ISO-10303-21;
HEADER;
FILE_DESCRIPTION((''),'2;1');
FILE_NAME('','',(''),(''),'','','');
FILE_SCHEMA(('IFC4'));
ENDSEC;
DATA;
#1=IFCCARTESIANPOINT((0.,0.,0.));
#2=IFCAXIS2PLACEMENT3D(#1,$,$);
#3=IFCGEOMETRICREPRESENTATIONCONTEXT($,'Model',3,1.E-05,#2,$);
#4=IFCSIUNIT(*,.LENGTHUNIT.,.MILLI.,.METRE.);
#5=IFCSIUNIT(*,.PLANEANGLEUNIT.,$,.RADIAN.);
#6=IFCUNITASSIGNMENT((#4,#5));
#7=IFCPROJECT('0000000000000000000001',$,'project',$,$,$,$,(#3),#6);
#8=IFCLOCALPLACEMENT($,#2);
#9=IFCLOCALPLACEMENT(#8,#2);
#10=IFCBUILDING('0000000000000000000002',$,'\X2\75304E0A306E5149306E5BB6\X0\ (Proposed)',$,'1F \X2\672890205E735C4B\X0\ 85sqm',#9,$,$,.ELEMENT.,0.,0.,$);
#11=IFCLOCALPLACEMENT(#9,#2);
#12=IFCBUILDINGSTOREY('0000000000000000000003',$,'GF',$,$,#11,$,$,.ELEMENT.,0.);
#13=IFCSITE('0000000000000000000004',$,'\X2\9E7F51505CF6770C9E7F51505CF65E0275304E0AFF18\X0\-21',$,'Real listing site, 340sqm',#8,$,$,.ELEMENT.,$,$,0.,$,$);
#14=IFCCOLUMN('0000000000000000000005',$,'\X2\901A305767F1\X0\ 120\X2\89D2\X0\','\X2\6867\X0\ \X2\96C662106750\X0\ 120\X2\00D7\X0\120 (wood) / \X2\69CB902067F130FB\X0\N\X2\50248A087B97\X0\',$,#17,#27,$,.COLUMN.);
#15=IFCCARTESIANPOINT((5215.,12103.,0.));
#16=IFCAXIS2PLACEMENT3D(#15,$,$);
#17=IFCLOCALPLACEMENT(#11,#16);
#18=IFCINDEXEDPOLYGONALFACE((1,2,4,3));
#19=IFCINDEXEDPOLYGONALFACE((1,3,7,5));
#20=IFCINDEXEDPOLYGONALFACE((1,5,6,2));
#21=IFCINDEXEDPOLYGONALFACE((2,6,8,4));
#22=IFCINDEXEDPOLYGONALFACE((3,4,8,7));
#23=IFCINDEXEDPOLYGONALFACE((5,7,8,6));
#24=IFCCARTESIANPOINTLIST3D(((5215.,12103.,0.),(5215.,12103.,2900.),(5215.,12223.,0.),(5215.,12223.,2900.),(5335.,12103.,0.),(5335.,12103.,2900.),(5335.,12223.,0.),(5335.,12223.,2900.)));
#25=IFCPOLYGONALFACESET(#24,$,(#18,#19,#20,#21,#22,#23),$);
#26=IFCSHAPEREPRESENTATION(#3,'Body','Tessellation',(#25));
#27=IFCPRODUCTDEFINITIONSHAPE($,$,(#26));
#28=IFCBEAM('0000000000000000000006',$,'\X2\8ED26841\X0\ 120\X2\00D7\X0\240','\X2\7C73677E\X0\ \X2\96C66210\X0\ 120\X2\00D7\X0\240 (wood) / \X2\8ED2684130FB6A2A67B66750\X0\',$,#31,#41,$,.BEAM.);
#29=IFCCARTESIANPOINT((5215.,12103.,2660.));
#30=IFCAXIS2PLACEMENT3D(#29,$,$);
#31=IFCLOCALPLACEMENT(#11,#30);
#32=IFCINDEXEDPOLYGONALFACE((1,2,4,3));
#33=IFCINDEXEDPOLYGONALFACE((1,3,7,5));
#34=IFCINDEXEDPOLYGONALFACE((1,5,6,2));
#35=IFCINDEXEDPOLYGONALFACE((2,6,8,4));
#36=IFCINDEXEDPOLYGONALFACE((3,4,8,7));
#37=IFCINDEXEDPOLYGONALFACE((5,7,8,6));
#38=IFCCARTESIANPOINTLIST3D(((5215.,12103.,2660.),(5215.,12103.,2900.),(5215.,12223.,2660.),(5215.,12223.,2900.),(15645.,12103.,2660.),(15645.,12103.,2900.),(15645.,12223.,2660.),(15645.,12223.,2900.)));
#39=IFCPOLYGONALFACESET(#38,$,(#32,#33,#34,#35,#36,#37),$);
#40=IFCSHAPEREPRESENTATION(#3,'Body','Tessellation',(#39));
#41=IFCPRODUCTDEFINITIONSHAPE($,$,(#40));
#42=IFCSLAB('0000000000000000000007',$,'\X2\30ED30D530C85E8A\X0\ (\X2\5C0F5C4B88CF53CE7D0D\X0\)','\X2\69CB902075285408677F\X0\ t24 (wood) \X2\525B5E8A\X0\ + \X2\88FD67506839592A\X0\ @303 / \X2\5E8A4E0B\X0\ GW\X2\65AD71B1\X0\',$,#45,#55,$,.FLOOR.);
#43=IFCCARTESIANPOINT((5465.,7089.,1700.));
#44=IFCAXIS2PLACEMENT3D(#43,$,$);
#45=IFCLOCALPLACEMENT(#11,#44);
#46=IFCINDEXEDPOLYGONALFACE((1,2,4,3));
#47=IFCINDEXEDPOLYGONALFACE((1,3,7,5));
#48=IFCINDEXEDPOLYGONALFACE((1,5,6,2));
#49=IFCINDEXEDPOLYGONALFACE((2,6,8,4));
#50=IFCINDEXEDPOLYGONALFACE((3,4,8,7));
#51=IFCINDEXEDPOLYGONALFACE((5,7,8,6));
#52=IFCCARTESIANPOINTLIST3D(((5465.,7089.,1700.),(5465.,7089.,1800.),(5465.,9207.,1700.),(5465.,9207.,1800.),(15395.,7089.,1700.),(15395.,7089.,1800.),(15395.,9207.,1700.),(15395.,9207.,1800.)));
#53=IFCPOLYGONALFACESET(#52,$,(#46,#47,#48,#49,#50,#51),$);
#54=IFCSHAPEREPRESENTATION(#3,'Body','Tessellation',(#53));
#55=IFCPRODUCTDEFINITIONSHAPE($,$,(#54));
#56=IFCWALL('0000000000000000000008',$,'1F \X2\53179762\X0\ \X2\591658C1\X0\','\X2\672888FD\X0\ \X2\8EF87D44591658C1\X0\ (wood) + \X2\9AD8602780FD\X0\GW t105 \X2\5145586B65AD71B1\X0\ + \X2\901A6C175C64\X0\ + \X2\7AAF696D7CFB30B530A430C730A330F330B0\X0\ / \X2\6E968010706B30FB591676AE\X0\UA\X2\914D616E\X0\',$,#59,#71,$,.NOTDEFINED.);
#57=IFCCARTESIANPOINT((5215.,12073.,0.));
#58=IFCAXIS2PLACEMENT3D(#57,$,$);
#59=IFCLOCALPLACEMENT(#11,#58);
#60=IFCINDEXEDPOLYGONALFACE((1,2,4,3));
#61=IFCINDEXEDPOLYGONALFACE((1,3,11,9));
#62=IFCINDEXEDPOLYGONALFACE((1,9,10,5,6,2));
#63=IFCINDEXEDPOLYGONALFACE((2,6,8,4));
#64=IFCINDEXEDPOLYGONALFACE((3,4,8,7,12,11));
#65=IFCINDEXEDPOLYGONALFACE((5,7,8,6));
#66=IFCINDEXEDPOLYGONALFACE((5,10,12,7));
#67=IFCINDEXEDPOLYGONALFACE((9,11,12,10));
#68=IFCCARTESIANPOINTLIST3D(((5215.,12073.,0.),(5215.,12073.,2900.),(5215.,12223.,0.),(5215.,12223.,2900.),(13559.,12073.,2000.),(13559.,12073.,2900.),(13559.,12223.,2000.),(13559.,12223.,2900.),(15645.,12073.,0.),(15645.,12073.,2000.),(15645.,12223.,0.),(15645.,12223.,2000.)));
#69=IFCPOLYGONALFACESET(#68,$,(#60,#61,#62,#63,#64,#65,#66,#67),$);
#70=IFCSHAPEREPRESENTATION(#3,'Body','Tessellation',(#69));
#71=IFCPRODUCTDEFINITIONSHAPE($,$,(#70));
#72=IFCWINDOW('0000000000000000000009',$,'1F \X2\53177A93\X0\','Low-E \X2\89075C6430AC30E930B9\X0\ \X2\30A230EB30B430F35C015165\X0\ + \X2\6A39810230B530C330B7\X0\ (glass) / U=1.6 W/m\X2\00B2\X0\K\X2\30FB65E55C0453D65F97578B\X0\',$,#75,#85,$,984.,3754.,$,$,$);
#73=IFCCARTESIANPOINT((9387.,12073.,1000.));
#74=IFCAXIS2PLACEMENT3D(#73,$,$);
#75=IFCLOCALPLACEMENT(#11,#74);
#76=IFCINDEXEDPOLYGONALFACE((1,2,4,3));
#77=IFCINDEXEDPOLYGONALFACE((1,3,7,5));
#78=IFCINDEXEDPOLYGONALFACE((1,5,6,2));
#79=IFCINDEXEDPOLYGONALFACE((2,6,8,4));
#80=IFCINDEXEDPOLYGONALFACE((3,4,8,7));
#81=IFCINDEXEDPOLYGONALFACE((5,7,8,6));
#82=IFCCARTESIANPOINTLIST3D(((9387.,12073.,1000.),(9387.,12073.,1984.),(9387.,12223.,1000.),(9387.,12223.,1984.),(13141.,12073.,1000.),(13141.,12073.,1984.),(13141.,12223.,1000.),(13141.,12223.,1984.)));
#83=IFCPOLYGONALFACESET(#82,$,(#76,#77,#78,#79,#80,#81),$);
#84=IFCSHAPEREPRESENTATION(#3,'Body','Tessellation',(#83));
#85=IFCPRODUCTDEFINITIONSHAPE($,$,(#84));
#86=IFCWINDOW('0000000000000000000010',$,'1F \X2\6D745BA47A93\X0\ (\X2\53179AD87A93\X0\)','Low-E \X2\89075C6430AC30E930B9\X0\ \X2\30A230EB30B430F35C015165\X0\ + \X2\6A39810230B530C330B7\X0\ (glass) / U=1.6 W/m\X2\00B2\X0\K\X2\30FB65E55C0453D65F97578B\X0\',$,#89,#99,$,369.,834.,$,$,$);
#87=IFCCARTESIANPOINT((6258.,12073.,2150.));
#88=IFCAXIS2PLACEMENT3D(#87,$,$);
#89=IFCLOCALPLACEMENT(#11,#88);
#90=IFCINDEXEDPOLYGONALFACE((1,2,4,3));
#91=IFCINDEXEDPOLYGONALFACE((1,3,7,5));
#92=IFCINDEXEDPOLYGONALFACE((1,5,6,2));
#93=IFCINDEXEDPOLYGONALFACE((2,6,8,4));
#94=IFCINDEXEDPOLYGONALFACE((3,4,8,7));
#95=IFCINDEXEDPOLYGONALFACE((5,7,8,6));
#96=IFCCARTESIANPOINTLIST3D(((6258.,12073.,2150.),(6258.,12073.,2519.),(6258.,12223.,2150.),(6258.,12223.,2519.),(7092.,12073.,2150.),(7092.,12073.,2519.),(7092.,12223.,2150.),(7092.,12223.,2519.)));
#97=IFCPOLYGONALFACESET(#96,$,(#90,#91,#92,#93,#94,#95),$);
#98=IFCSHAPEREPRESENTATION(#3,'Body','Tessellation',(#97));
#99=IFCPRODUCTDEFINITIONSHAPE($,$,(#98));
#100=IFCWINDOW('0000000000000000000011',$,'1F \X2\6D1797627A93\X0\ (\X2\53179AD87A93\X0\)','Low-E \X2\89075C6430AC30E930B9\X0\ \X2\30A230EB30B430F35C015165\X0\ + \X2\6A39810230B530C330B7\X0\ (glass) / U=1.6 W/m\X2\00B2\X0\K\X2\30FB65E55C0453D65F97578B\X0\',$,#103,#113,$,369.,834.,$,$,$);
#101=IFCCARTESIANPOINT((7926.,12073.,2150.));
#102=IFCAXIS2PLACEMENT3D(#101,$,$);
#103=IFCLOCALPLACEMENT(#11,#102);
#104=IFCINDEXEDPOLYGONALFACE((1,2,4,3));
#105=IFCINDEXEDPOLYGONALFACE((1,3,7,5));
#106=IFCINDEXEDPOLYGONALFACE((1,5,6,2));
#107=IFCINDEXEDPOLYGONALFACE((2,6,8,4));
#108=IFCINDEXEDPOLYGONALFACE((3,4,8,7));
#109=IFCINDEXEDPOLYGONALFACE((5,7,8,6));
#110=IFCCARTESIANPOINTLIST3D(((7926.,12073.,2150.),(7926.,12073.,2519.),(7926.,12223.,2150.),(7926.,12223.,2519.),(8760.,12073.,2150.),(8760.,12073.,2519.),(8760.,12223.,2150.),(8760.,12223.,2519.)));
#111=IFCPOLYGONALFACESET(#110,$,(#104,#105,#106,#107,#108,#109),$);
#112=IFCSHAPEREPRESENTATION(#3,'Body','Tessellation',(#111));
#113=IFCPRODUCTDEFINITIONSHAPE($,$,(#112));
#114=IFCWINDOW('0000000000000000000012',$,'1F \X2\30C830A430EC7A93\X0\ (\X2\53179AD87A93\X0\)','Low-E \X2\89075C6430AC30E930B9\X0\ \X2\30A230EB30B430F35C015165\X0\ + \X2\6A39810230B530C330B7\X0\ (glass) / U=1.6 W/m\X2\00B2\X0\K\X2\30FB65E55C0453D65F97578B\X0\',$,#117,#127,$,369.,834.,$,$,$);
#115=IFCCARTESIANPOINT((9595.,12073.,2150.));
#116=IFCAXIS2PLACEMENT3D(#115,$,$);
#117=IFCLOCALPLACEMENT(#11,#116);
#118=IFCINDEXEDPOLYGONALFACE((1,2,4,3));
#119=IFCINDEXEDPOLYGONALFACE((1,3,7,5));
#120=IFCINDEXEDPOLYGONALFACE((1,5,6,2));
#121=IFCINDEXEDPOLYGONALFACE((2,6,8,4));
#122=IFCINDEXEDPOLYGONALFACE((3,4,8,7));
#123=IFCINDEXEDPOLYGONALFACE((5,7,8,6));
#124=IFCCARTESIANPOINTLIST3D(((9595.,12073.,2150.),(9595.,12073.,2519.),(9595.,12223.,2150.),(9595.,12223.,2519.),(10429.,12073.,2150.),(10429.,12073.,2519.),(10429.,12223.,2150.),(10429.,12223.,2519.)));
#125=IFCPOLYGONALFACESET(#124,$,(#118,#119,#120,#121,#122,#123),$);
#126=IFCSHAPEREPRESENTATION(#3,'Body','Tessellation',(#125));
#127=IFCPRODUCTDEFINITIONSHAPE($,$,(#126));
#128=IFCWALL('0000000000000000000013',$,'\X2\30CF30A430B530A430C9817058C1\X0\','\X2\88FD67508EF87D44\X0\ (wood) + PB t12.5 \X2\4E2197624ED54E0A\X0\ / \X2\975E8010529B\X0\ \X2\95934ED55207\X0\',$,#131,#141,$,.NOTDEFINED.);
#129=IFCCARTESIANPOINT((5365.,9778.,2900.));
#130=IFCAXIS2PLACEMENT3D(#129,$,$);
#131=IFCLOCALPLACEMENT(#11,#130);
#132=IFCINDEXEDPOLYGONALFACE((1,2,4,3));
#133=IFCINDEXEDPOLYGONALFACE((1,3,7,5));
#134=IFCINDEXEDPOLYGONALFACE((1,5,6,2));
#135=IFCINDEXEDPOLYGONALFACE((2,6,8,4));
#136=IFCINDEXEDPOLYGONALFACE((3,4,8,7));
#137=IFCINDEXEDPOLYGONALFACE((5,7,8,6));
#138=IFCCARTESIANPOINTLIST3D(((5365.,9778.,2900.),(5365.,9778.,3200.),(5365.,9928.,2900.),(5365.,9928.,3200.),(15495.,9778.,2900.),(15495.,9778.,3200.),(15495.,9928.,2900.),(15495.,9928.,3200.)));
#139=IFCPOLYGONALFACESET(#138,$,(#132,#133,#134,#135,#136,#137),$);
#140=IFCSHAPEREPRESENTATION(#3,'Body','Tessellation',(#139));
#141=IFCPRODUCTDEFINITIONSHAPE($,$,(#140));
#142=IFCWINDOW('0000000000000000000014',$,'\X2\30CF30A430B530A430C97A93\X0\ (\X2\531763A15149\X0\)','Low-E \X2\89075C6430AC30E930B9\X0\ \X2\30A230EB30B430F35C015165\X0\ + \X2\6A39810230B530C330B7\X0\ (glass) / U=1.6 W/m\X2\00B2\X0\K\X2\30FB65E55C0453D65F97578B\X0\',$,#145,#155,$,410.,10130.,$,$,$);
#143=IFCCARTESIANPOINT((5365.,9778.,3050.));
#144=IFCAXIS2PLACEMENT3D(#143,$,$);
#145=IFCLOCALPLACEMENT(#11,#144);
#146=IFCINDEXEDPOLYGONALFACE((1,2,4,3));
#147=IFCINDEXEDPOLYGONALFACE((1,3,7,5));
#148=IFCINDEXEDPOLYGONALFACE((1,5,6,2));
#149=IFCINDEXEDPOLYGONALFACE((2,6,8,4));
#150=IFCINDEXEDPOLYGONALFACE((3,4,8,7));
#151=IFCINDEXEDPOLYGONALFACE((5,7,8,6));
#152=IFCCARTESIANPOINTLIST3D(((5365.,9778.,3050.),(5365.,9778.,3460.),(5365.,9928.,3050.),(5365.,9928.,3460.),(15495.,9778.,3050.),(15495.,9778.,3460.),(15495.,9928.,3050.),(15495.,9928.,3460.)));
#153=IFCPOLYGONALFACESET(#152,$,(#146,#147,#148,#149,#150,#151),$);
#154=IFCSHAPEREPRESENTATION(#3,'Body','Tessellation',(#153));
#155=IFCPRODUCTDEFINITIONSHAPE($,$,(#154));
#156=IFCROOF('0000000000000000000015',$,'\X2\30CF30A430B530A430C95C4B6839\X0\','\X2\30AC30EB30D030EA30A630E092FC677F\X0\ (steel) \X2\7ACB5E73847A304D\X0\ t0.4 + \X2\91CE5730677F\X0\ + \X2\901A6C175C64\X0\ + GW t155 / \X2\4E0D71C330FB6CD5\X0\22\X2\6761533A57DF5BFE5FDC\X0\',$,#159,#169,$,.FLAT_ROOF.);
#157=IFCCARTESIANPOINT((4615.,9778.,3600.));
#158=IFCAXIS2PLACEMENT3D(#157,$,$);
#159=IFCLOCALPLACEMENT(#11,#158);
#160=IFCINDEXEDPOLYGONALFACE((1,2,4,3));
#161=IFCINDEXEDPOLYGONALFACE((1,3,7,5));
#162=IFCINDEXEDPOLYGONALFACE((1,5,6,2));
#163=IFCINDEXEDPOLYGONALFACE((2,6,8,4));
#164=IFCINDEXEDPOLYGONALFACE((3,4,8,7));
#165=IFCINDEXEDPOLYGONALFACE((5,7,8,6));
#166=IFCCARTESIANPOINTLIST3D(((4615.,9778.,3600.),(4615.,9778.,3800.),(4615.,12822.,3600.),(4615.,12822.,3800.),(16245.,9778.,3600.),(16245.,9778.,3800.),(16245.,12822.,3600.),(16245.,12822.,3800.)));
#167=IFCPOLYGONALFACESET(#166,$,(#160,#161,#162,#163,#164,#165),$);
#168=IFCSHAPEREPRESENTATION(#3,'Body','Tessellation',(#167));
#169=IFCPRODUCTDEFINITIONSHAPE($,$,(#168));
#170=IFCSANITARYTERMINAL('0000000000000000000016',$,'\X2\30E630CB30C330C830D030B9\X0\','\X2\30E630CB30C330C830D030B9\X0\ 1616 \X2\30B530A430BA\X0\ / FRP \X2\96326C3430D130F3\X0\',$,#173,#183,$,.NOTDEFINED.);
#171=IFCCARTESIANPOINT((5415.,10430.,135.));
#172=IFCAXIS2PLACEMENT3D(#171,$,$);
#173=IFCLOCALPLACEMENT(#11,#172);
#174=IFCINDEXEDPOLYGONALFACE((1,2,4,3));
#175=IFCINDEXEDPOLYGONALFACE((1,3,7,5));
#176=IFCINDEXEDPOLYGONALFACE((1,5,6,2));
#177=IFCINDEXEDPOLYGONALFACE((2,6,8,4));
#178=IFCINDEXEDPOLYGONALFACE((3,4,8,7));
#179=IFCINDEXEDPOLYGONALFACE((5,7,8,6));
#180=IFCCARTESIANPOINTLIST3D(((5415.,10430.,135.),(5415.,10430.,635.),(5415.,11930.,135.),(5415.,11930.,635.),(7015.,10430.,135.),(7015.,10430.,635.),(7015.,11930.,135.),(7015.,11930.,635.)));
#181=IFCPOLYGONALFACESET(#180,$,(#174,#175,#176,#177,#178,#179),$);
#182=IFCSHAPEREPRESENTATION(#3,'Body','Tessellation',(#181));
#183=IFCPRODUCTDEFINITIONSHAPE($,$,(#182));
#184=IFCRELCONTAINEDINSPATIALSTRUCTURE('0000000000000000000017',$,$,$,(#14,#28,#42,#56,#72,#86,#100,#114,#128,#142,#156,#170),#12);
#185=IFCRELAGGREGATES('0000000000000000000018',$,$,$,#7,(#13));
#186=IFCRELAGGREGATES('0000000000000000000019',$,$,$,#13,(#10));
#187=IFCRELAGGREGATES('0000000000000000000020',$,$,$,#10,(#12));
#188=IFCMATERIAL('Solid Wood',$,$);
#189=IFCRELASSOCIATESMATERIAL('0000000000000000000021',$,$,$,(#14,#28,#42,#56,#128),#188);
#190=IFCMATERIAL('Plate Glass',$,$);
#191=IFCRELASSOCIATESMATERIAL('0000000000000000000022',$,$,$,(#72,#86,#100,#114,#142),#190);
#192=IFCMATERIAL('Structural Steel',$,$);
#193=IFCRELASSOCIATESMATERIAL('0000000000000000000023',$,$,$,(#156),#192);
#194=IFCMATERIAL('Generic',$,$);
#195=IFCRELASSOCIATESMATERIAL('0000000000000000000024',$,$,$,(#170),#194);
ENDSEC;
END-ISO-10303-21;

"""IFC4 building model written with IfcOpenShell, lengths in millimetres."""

from ifc_helpers import new_model, si_unit, frame, frame_2d, origin, place, context, project, spatial, rectangle, extrude, material, element, fill, save


model = new_model("IFC4")

# Units and contexts
model_context = context("Model", 3, precision=1e-05, world=origin())
ifc_project = project(units=[si_unit("LENGTHUNIT", "METRE", prefix="MILLI"), si_unit("PLANEANGLEUNIT", "RADIAN")], contexts=[model_context])

# Site, building, storey
site_placement = place(None, origin())
site = spatial("IfcSite", under=ifc_project, at=site_placement, Name="鹿児島県鹿児島市田上８-21", ObjectType="Real listing site, 340sqm", CompositionType="ELEMENT", RefElevation=0.0)
building_placement = place(site_placement, origin())
building = spatial("IfcBuilding", under=site, at=building_placement, Name="田上の光の家 (Proposed)", ObjectType="1F 木造平屋 85sqm", CompositionType="ELEMENT", ElevationOfRefHeight=0.0, ElevationOfTerrain=0.0)
storey_placement = place(building_placement, origin())
storey = spatial("IfcBuildingStorey", under=building, at=storey_placement, Name="GF", CompositionType="ELEMENT", Elevation=0.0)

# Column
ifc_material_1 = material(Name="Solid Wood")
column_1_placement = place(storey_placement, frame((5215.0, 12103.0, 0.0)))
element("IfcColumn", 1, at=column_1_placement, inside=storey, material=ifc_material_1, Name="通し柱 120角", Description="桧 集成材 120×120 (wood) / 構造柱・N値計算", PredefinedType="COLUMN", context=model_context, shape_type="SweptSolid", body=[
    extrude(rectangle(XDim=120.0, YDim=120.0, at=frame_2d((60.0, 60.0))), frame((5215.0, 12103.0, 0.0)), (0.0, 0.0, 1.0), 2900.0),
])

# Beam
beam_1_placement = place(storey_placement, frame((5215.0, 12103.0, 2660.0)))
element("IfcBeam", 2, at=beam_1_placement, inside=storey, material=ifc_material_1, Name="軒桁 120×240", Description="米松 集成 120×240 (wood) / 軒桁・横架材", PredefinedType="BEAM", context=model_context, shape_type="SweptSolid", body=[
    extrude(rectangle(XDim=10430.0, YDim=120.0, at=frame_2d((5215.0, 60.0))), frame((5215.0, 12103.0, 2660.0)), (0.0, 0.0, 1.0), 240.0),
])

# Slab
slab_placement = place(storey_placement, frame((5465.0, 7089.0, 1700.0)))
element("IfcSlab", 3, at=slab_placement, inside=storey, material=ifc_material_1, Name="ロフト床 (小屋裏収納)", Description="構造用合板 t24 (wood) 剛床 + 製材根太 @303 / 床下 GW断熱", PredefinedType="FLOOR", context=model_context, shape_type="SweptSolid", body=[
    extrude(rectangle(XDim=9930.0, YDim=2118.0, at=frame_2d((4965.0, 1059.0))), frame((5465.0, 7089.0, 1700.0)), (0.0, 0.0, 1.0), 100.0),
])

# Wall, openings, windows
wall_1_placement = place(storey_placement, frame((5215.0, 12073.0, 0.0)))
wall_1 = element("IfcWall", 4, at=wall_1_placement, inside=storey, material=ifc_material_1, Name="1F 北面 外壁", Description="木製 軸組外壁 (wood) + 高性能GW t105 充填断熱 + 通気層 + 窯業系サイディング / 準耐火・外皮UA配慮", PredefinedType="NOTDEFINED", context=model_context, shape_type="SweptSolid", body=[
    extrude(rectangle(XDim=10430.0, YDim=150.0, at=frame_2d((5215.0, 75.0))), frame((5215.0, 12073.0, 0.0)), (0.0, 0.0, 1.0), 2900.0),
])
opening_1_placement = place(storey_placement, frame((9387.0, 12073.0, 1000.0)))
opening_1 = element("IfcOpeningElement", 5, at=opening_1_placement, cuts=wall_1, PredefinedType="NOTDEFINED", context=model_context, shape_type="SweptSolid", body=[
    extrude(rectangle(XDim=3754.0, YDim=150.0, at=frame_2d((1877.0, 75.0))), frame((9387.0, 12073.0, 1000.0)), (0.0, 0.0, 1.0), 984.0),
])
opening_2_placement = place(storey_placement, frame((6258.0, 12073.0, 2150.0)))
opening_2 = element("IfcOpeningElement", 6, at=opening_2_placement, cuts=wall_1, PredefinedType="NOTDEFINED", context=model_context, shape_type="SweptSolid", body=[
    extrude(rectangle(XDim=834.0, YDim=150.0, at=frame_2d((417.0, 75.0))), frame((6258.0, 12073.0, 2150.0)), (0.0, 0.0, 1.0), 369.0),
])
opening_3_placement = place(storey_placement, frame((7926.0, 12073.0, 2150.0)))
opening_3 = element("IfcOpeningElement", 7, at=opening_3_placement, cuts=wall_1, PredefinedType="NOTDEFINED", context=model_context, shape_type="SweptSolid", body=[
    extrude(rectangle(XDim=834.0, YDim=150.0, at=frame_2d((417.0, 75.0))), frame((7926.0, 12073.0, 2150.0)), (0.0, 0.0, 1.0), 369.0),
])
opening_4_placement = place(storey_placement, frame((9595.0, 12073.0, 2150.0)))
opening_4 = element("IfcOpeningElement", 8, at=opening_4_placement, cuts=wall_1, PredefinedType="NOTDEFINED", context=model_context, shape_type="SweptSolid", body=[
    extrude(rectangle(XDim=834.0, YDim=150.0, at=frame_2d((417.0, 75.0))), frame((9595.0, 12073.0, 2150.0)), (0.0, 0.0, 1.0), 369.0),
])
ifc_material_2 = material(Name="Plate Glass")
window_1_placement = place(storey_placement, frame((9387.0, 12073.0, 1000.0)))
window_1 = element("IfcWindow", 9, at=window_1_placement, inside=storey, material=ifc_material_2, Name="1F 北窓", Description="Low-E 複層ガラス アルゴン封入 + 樹脂サッシ (glass) / U=1.6 W/m²K・日射取得型", OverallHeight=984.0, OverallWidth=3754.0, context=model_context, shape_type="SweptSolid", body=[
    extrude(rectangle(XDim=3754.0, YDim=150.0, at=frame_2d((1877.0, 75.0))), frame((9387.0, 12073.0, 1000.0)), (0.0, 0.0, 1.0), 984.0),
])
fill(opening_1, window_1)
window_2_placement = place(storey_placement, frame((6258.0, 12073.0, 2150.0)))
window_2 = element("IfcWindow", 10, at=window_2_placement, inside=storey, material=ifc_material_2, Name="1F 浴室窓 (北高窓)", Description="Low-E 複層ガラス アルゴン封入 + 樹脂サッシ (glass) / U=1.6 W/m²K・日射取得型", OverallHeight=369.0, OverallWidth=834.0, context=model_context, shape_type="SweptSolid", body=[
    extrude(rectangle(XDim=834.0, YDim=150.0, at=frame_2d((417.0, 75.0))), frame((6258.0, 12073.0, 2150.0)), (0.0, 0.0, 1.0), 369.0),
])
fill(opening_2, window_2)
window_3_placement = place(storey_placement, frame((7926.0, 12073.0, 2150.0)))
window_3 = element("IfcWindow", 11, at=window_3_placement, inside=storey, material=ifc_material_2, Name="1F 洗面窓 (北高窓)", Description="Low-E 複層ガラス アルゴン封入 + 樹脂サッシ (glass) / U=1.6 W/m²K・日射取得型", OverallHeight=369.0, OverallWidth=834.0, context=model_context, shape_type="SweptSolid", body=[
    extrude(rectangle(XDim=834.0, YDim=150.0, at=frame_2d((417.0, 75.0))), frame((7926.0, 12073.0, 2150.0)), (0.0, 0.0, 1.0), 369.0),
])
fill(opening_3, window_3)
window_4_placement = place(storey_placement, frame((9595.0, 12073.0, 2150.0)))
window_4 = element("IfcWindow", 12, at=window_4_placement, inside=storey, material=ifc_material_2, Name="1F トイレ窓 (北高窓)", Description="Low-E 複層ガラス アルゴン封入 + 樹脂サッシ (glass) / U=1.6 W/m²K・日射取得型", OverallHeight=369.0, OverallWidth=834.0, context=model_context, shape_type="SweptSolid", body=[
    extrude(rectangle(XDim=834.0, YDim=150.0, at=frame_2d((417.0, 75.0))), frame((9595.0, 12073.0, 2150.0)), (0.0, 0.0, 1.0), 369.0),
])
fill(opening_4, window_4)

# Wall, opening, window
wall_2_placement = place(storey_placement, frame((5365.0, 9778.0, 2900.0)))
wall_2 = element("IfcWall", 13, at=wall_2_placement, inside=storey, material=ifc_material_1, Name="ハイサイド腰壁", Description="製材軸組 (wood) + PB t12.5 両面仕上 / 非耐力 間仕切", PredefinedType="NOTDEFINED", context=model_context, shape_type="SweptSolid", body=[
    extrude(rectangle(XDim=10130.0, YDim=150.0, at=frame_2d((5065.0, 75.0))), frame((5365.0, 9778.0, 2900.0)), (0.0, 0.0, 1.0), 700.0),
])
opening_5_placement = place(storey_placement, frame((5365.0, 9778.0, 3050.0)))
opening_5 = element("IfcOpeningElement", 14, at=opening_5_placement, cuts=wall_2, PredefinedType="NOTDEFINED", context=model_context, shape_type="SweptSolid", body=[
    extrude(rectangle(XDim=10130.0, YDim=150.0, at=frame_2d((5065.0, 75.0))), frame((5365.0, 9778.0, 3050.0)), (0.0, 0.0, 1.0), 410.0),
])
window_5_placement = place(storey_placement, frame((5365.0, 9778.0, 3050.0)))
window_5 = element("IfcWindow", 15, at=window_5_placement, inside=storey, material=ifc_material_2, Name="ハイサイド窓 (北採光)", Description="Low-E 複層ガラス アルゴン封入 + 樹脂サッシ (glass) / U=1.6 W/m²K・日射取得型", OverallHeight=410.0, OverallWidth=10130.0, context=model_context, shape_type="SweptSolid", body=[
    extrude(rectangle(XDim=10130.0, YDim=150.0, at=frame_2d((5065.0, 75.0))), frame((5365.0, 9778.0, 3050.0)), (0.0, 0.0, 1.0), 410.0),
])
fill(opening_5, window_5)

# Roof
ifc_material_3 = material(Name="Structural Steel")
roof_placement = place(storey_placement, frame((4615.0, 9778.0, 3600.0)))
element("IfcRoof", 16, at=roof_placement, inside=storey, material=ifc_material_3, Name="ハイサイド屋根", Description="ガルバリウム鋼板 (steel) 立平葺き t0.4 + 野地板 + 通気層 + GW t155 / 不燃・法22条区域対応", PredefinedType="FLAT_ROOF", context=model_context, shape_type="SweptSolid", body=[
    extrude(rectangle(XDim=11630.0, YDim=3044.0, at=frame_2d((5815.0, 1522.0))), frame((4615.0, 9778.0, 3600.0)), (0.0, 0.0, 1.0), 200.0),
])

# Sanitary terminal
ifc_material_4 = material(Name="Generic")
sanitary_terminal_placement = place(storey_placement, frame((5415.0, 10430.0, 135.0)))
element("IfcSanitaryTerminal", 17, at=sanitary_terminal_placement, inside=storey, material=ifc_material_4, Name="ユニットバス", Description="ユニットバス 1616 サイズ / FRP 防水パン", PredefinedType="NOTDEFINED", context=model_context, shape_type="SweptSolid", body=[
    extrude(rectangle(XDim=1600.0, YDim=1500.0, at=frame_2d((800.0, 750.0))), frame((5415.0, 10430.0, 135.0)), (0.0, 0.0, 1.0), 500.0),
])

save(model, "model.ifc")
